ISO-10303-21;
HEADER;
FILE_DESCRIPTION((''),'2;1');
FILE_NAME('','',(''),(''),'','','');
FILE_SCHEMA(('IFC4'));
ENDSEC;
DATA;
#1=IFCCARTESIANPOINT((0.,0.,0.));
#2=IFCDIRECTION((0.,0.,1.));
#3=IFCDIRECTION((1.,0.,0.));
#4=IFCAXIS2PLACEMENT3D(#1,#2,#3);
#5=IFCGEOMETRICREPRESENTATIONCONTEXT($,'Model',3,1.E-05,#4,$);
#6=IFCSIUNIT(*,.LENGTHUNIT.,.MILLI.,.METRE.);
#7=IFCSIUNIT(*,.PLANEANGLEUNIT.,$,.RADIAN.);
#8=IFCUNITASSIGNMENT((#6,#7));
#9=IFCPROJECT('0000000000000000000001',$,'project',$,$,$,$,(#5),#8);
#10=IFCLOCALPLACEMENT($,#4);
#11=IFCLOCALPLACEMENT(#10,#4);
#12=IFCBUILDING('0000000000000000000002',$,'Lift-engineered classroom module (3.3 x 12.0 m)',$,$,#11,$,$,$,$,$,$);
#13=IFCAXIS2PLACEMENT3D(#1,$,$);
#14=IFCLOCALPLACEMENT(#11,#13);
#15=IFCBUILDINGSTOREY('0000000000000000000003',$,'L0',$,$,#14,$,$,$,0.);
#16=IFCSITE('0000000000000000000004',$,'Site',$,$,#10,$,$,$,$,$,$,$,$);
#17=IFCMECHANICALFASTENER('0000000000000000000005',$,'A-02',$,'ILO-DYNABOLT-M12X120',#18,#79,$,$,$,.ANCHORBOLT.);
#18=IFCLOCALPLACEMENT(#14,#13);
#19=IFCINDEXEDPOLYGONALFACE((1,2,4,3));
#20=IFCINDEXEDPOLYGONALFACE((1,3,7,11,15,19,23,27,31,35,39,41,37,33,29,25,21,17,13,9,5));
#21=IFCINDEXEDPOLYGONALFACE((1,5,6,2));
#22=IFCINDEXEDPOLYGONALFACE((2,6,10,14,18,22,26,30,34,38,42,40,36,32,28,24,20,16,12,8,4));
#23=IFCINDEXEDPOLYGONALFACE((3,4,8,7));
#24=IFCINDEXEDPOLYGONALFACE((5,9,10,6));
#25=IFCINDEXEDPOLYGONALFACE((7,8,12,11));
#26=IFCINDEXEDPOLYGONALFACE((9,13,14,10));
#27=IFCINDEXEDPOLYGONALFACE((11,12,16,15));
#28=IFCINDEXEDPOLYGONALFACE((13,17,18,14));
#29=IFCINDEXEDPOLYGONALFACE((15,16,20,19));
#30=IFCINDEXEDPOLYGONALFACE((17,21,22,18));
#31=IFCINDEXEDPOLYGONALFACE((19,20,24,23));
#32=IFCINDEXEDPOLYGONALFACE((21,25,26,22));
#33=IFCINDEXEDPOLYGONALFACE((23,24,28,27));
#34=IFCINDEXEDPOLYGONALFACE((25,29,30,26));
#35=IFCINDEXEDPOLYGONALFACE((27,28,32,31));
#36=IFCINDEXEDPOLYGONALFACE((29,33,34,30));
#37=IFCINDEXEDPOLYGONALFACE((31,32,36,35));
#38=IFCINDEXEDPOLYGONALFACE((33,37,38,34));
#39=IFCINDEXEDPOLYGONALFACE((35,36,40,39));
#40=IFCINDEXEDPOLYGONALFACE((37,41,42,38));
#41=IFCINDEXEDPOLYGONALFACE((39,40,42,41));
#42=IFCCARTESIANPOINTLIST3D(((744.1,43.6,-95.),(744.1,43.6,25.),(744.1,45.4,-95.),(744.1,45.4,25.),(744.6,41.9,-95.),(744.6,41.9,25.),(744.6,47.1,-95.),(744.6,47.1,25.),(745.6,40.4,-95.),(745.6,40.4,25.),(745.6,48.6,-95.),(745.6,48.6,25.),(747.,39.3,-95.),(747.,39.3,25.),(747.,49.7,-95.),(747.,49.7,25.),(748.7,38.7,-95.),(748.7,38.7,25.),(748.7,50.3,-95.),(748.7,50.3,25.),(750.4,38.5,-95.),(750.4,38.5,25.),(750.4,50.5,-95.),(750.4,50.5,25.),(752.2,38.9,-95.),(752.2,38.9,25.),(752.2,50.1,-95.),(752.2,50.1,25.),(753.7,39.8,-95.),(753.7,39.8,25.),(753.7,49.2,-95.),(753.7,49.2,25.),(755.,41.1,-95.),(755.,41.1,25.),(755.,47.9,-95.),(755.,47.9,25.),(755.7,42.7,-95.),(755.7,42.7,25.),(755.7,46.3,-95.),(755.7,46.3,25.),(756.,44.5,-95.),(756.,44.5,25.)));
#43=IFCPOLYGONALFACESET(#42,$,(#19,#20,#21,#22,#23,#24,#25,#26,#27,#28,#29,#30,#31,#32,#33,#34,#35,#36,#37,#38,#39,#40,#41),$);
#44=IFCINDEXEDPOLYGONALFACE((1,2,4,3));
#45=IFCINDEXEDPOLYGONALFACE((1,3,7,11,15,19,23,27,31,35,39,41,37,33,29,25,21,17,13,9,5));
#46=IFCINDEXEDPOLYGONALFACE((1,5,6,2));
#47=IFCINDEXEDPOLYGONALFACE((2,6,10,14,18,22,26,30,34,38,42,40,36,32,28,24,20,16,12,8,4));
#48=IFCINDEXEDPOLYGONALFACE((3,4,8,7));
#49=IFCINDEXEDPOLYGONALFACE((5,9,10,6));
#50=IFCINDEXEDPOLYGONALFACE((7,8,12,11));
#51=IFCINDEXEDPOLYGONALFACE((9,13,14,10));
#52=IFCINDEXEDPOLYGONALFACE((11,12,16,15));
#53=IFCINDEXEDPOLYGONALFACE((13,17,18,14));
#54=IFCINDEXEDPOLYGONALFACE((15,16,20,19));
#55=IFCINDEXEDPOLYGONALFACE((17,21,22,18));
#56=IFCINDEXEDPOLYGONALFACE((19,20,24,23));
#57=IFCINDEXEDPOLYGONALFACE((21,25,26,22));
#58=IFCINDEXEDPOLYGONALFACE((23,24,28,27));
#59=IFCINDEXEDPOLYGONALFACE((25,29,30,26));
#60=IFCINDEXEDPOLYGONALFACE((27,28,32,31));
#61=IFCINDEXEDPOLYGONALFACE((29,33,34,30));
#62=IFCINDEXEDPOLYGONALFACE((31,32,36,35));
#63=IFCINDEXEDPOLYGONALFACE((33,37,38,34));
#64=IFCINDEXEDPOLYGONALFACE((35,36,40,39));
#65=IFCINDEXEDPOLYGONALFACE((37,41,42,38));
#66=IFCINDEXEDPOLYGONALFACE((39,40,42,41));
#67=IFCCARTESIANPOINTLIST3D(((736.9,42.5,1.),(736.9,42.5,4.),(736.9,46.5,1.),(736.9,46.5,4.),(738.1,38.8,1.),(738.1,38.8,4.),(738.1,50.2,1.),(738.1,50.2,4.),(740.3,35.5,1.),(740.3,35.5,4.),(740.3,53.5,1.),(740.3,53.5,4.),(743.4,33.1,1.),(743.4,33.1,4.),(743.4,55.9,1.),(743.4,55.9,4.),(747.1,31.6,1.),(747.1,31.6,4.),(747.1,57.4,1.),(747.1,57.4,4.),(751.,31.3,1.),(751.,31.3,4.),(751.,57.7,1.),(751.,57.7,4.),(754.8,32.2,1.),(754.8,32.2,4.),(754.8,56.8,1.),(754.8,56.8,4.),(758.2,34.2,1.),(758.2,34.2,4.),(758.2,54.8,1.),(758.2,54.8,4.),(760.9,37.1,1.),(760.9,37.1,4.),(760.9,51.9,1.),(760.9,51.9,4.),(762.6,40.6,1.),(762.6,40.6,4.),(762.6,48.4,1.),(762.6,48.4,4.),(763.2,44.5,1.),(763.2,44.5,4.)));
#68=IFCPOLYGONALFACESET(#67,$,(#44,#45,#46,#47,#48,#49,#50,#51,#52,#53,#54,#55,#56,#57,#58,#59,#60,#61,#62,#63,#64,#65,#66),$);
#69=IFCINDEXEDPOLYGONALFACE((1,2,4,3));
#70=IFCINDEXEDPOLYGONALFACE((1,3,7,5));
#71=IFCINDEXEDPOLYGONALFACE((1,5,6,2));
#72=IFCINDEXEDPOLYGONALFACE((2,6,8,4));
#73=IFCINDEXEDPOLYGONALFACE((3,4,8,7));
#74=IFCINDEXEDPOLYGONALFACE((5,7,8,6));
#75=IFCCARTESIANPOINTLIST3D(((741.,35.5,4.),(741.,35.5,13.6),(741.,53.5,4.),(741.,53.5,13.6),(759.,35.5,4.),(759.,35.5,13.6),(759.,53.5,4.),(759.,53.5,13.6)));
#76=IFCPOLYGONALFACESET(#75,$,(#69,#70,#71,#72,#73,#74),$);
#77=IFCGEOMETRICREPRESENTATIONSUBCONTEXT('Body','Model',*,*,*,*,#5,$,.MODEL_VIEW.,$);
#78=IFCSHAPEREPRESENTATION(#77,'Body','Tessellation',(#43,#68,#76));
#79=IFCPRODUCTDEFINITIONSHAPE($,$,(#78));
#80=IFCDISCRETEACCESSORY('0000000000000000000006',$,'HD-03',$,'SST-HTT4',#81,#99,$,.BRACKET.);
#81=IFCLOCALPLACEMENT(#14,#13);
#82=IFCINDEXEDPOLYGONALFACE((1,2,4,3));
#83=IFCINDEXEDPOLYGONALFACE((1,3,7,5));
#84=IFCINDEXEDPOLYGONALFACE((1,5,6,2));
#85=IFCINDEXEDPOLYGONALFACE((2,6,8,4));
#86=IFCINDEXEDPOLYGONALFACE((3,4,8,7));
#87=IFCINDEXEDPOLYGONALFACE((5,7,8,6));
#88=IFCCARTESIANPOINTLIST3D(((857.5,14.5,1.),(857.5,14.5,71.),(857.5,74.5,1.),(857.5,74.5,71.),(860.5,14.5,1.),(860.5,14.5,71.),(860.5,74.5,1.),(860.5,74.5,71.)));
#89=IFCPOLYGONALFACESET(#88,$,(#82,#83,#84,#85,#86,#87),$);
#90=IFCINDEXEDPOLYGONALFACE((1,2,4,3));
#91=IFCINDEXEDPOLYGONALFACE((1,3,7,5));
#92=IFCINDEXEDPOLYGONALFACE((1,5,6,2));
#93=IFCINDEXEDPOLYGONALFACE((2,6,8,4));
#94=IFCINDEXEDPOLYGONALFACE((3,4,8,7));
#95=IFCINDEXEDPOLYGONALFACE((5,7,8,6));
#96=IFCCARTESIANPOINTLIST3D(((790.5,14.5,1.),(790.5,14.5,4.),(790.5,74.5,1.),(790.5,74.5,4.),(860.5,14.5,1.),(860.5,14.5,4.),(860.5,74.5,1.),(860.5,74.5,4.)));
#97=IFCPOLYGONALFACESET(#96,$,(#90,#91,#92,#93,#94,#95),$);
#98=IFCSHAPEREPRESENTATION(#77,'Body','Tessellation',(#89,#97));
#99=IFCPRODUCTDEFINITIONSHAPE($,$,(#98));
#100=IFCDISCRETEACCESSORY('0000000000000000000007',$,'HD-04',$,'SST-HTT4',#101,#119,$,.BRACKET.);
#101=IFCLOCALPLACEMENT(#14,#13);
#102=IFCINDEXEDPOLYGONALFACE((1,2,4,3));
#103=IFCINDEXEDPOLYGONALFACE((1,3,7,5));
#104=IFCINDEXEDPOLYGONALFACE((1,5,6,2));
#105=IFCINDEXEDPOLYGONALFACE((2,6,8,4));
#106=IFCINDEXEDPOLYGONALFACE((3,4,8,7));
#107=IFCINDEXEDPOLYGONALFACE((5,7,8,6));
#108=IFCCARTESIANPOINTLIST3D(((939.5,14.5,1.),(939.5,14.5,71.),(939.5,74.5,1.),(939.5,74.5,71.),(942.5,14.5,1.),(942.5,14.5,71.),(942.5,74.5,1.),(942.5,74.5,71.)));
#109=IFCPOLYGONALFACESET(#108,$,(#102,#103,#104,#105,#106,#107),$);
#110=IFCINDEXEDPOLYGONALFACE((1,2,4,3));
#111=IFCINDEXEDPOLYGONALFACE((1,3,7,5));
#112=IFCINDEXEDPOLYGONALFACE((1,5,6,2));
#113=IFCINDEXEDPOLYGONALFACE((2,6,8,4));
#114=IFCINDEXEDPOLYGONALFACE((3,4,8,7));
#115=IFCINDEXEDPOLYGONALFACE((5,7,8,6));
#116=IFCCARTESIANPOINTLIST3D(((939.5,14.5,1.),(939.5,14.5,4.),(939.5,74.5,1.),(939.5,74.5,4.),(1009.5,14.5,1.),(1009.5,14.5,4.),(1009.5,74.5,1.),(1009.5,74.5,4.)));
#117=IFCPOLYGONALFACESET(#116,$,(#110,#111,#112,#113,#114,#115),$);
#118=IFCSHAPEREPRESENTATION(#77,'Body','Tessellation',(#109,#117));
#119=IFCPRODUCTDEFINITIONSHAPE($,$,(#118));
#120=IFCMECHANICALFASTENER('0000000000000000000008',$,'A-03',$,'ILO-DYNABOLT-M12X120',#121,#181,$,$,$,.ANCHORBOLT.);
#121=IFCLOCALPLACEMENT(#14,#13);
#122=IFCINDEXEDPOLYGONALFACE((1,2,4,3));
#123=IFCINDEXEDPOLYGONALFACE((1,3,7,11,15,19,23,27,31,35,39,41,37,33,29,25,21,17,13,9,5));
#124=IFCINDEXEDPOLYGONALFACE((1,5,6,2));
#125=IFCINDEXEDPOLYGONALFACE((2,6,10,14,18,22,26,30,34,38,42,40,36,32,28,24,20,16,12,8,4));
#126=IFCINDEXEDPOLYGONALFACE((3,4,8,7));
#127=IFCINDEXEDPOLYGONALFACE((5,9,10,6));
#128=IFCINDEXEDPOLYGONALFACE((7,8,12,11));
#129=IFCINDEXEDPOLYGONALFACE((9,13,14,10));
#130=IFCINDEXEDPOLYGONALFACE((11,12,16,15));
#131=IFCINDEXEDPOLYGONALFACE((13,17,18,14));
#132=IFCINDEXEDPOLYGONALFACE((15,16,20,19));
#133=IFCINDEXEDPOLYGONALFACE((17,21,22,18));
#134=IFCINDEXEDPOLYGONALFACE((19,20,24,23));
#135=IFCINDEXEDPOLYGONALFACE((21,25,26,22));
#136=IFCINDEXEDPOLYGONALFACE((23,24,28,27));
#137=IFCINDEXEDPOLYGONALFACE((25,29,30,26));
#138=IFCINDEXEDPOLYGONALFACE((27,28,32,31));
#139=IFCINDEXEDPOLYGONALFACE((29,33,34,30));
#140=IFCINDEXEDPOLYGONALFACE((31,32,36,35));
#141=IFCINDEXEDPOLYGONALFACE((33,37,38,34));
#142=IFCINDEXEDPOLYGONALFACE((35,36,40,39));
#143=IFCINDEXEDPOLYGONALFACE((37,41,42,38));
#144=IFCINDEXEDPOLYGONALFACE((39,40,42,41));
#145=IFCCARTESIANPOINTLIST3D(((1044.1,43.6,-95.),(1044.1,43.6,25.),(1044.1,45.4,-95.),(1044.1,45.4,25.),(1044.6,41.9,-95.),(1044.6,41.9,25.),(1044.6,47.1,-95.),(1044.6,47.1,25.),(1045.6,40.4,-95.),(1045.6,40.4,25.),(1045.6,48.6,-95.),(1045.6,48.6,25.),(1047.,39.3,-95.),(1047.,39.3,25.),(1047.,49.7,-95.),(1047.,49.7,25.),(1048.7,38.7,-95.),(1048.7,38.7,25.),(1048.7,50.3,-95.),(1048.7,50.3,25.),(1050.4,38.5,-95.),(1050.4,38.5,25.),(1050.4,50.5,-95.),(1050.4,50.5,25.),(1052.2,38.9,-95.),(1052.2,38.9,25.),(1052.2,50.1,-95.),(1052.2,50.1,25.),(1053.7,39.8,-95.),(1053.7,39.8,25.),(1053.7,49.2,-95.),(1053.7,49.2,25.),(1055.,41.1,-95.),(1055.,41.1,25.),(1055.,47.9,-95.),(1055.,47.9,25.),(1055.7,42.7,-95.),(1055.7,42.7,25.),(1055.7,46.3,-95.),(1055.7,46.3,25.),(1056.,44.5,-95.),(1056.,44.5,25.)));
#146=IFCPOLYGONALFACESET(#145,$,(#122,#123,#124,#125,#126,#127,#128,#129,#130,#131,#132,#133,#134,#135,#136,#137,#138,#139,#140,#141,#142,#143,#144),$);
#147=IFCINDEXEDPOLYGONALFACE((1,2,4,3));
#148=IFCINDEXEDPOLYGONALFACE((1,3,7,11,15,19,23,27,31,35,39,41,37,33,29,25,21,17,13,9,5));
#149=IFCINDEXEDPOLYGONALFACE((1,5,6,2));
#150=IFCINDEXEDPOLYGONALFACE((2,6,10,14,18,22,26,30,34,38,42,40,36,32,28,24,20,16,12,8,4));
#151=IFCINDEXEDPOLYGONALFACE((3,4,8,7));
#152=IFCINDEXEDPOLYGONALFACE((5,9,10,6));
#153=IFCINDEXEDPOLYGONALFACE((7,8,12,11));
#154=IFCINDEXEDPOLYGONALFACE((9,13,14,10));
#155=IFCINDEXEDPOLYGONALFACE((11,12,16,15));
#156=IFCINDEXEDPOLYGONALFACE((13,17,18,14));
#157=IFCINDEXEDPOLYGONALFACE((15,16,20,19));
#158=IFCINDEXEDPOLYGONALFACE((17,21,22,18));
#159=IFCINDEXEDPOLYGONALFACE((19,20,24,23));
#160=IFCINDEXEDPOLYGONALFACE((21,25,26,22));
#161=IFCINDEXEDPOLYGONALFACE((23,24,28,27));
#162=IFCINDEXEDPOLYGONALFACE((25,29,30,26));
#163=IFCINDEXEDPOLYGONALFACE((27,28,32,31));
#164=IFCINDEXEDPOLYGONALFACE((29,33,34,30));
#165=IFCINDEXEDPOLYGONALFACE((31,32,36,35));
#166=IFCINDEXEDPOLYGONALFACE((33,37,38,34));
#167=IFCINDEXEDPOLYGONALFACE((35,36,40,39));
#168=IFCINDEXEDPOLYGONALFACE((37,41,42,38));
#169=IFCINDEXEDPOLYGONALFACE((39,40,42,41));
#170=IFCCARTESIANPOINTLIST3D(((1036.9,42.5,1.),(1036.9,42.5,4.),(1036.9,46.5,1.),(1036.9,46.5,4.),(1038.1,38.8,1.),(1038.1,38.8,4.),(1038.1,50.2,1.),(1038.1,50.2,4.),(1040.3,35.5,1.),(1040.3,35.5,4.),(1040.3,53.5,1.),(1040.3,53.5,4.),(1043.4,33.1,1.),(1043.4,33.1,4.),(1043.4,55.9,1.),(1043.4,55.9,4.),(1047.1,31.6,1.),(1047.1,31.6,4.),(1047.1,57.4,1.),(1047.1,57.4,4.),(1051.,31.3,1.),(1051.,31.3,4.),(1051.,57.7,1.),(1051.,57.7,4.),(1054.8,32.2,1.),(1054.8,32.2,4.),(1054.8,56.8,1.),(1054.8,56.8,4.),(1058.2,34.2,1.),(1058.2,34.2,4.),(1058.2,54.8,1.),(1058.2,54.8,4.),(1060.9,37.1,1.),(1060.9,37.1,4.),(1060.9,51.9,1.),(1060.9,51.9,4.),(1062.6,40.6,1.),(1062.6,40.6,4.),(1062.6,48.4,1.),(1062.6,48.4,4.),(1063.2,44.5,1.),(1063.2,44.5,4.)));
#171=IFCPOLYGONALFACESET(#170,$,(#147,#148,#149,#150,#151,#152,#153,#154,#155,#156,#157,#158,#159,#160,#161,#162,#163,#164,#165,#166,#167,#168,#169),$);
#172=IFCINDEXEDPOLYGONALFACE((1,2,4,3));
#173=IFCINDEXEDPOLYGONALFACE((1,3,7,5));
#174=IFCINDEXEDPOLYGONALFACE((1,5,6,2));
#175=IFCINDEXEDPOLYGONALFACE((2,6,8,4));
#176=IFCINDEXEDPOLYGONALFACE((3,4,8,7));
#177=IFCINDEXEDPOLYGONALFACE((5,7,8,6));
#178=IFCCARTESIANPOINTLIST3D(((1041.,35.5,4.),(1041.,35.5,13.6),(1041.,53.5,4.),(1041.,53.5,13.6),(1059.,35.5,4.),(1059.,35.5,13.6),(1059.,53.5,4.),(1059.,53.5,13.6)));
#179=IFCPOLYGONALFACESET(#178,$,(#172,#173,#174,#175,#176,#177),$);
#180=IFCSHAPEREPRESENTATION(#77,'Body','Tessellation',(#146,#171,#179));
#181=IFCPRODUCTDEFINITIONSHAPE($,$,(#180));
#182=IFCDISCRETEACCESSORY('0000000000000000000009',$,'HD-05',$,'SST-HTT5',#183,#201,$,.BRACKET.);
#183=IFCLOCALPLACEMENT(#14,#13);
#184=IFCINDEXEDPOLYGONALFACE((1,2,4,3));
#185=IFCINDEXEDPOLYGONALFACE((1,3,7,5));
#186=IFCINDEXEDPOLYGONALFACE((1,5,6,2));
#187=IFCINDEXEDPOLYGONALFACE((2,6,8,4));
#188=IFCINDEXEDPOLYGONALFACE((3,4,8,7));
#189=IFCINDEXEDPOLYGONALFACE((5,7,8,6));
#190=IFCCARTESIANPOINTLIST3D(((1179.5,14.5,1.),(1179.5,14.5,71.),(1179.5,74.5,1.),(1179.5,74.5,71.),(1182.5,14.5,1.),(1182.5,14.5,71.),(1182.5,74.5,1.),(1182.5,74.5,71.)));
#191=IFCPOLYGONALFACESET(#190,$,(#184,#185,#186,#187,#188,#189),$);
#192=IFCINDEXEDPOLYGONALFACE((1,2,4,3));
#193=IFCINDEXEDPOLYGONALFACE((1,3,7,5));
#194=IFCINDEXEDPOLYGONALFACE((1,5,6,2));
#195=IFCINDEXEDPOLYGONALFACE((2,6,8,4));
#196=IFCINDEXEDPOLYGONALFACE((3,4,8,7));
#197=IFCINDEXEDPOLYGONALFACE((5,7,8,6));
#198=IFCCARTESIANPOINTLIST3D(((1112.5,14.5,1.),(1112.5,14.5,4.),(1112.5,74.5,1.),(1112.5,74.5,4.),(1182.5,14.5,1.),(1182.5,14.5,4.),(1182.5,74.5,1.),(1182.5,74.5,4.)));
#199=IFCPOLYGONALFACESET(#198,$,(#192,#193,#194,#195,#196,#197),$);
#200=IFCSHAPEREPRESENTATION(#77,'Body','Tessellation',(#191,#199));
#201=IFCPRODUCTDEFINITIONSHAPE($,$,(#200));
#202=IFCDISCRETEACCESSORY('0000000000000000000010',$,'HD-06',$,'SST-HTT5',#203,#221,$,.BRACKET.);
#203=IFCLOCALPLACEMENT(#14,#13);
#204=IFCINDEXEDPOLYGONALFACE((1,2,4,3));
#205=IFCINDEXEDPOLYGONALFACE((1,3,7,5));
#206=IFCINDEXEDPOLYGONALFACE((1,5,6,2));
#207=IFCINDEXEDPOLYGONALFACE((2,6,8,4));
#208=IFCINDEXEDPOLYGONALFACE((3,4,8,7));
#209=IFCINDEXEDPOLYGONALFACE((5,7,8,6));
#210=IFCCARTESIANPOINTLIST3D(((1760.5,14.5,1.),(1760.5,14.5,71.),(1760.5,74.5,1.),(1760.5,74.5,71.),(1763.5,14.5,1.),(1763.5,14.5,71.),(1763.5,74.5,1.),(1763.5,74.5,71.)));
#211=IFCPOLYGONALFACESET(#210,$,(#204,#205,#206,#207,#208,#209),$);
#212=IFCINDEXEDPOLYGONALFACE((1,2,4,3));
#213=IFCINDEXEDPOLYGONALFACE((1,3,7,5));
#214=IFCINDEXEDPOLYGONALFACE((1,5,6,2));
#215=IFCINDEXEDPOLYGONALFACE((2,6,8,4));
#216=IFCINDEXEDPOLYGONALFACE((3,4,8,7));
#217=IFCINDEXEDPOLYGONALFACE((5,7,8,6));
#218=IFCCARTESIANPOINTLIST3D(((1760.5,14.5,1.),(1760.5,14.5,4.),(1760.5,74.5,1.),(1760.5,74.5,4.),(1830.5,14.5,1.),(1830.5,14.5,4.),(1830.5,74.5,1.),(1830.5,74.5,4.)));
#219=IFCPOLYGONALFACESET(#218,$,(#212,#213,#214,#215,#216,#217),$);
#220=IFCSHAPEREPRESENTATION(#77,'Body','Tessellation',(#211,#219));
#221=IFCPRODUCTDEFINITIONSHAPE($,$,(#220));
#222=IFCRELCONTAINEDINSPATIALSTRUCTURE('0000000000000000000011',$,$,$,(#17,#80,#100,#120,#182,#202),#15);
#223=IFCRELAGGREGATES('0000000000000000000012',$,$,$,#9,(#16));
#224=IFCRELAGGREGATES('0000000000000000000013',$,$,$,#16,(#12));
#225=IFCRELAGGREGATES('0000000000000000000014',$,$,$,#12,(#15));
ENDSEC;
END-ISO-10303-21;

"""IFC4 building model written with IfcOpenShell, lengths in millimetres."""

from ifc_helpers import new_model, si_unit, frame, frame_2d, origin, origin_with_axes, origin_2d, place, context, subcontext, project, spatial, rectangle, circle, extrude, element, save


model = new_model("IFC4")

# Units and contexts
model_context = context("Model", 3, precision=1e-05, world=origin_with_axes())
body_context = subcontext(model_context, "Body", "Model", "MODEL_VIEW")
ifc_project = project(units=[si_unit("LENGTHUNIT", "METRE", prefix="MILLI"), si_unit("PLANEANGLEUNIT", "RADIAN")], contexts=[model_context])

# Site, building, storey
site_placement = place(None, origin_with_axes())
site = spatial("IfcSite", under=ifc_project, at=site_placement, Name="Site")
building_placement = place(site_placement, origin_with_axes())
building = spatial("IfcBuilding", under=site, at=building_placement, Name="Lift-engineered classroom module (3.3 x 12.0 m)")
storey_placement = place(building_placement, origin())
storey = spatial("IfcBuildingStorey", under=building, at=storey_placement, Name="L0", Elevation=0.0)

# Mechanical fastener
mechanical_fastener_1_placement = place(None, frame((750.0, 44.5, 0.0), z_axis=(0.0, 0.0, 1.0), x_axis=(1.0, 0.0, 0.0)))
element("IfcMechanicalFastener", 1, at=mechanical_fastener_1_placement, inside=storey, Name="A-02", ObjectType="ILO-DYNABOLT-M12X120", PredefinedType="ANCHORBOLT", context=body_context, shape_type="SweptSolid", body=[
    extrude(circle(Radius=6.0, at=origin_2d()), frame((0.0, 0.0, -95.0), z_axis=(0.0, 0.0, 1.0), x_axis=(1.0, 0.0, 0.0)), (0.0, 0.0, 1.0), 120.0),
    extrude(circle(Radius=13.2, at=origin_2d()), frame((0.0, 0.0, 1.0), z_axis=(0.0, 0.0, 1.0), x_axis=(1.0, 0.0, 0.0)), (0.0, 0.0, 1.0), 3.0),
    extrude(rectangle(XDim=18.0, YDim=18.0, at=origin_2d()), frame((0.0, 0.0, 4.0), z_axis=(0.0, 0.0, 1.0), x_axis=(1.0, 0.0, 0.0)), (0.0, 0.0, 1.0), 9.6),
])

# Discrete accessories
for number, where, z_axis, x_axis, name in (
    (2, (860.5, 44.5, 0.0), (0.0, 0.0, 1.0), (-1.0, 0.0, 0.0), "HD-03"),
    (3, (939.5, 44.5, 0.0), (0.0, 0.0, 1.0), (1.0, 0.0, 0.0), "HD-04"),
):
    element("IfcDiscreteAccessory", number, at=place(None, frame(where, z_axis=z_axis, x_axis=x_axis)), inside=storey, Name=name, ObjectType="SST-HTT4", PredefinedType="BRACKET", context=body_context, shape_type="SweptSolid", body=[
        extrude(rectangle(XDim=3.0, YDim=60.0, at=frame_2d((1.5, 0.0))), frame((0.0, 0.0, 1.0), z_axis=(0.0, 0.0, 1.0), x_axis=(1.0, 0.0, 0.0)), (0.0, 0.0, 1.0), 70.0),
        extrude(rectangle(XDim=70.0, YDim=60.0, at=frame_2d((35.0, 0.0))), frame((0.0, 0.0, 1.0), z_axis=(0.0, 0.0, 1.0), x_axis=(1.0, 0.0, 0.0)), (0.0, 0.0, 1.0), 3.0),
    ])

# Mechanical fastener
mechanical_fastener_2_placement = place(None, frame((1050.0, 44.5, 0.0), z_axis=(0.0, 0.0, 1.0), x_axis=(1.0, 0.0, 0.0)))
element("IfcMechanicalFastener", 4, at=mechanical_fastener_2_placement, inside=storey, Name="A-03", ObjectType="ILO-DYNABOLT-M12X120", PredefinedType="ANCHORBOLT", context=body_context, shape_type="SweptSolid", body=[
    extrude(circle(Radius=6.0, at=origin_2d()), frame((0.0, 0.0, -95.0), z_axis=(0.0, 0.0, 1.0), x_axis=(1.0, 0.0, 0.0)), (0.0, 0.0, 1.0), 120.0),
    extrude(circle(Radius=13.2, at=origin_2d()), frame((0.0, 0.0, 1.0), z_axis=(0.0, 0.0, 1.0), x_axis=(1.0, 0.0, 0.0)), (0.0, 0.0, 1.0), 3.0),
    extrude(rectangle(XDim=18.0, YDim=18.0, at=origin_2d()), frame((0.0, 0.0, 4.0), z_axis=(0.0, 0.0, 1.0), x_axis=(1.0, 0.0, 0.0)), (0.0, 0.0, 1.0), 9.6),
])

# Discrete accessories
for number, where, z_axis, x_axis, name in (
    (5, (1182.5, 44.5, 0.0), (0.0, 0.0, 1.0), (-1.0, 0.0, 0.0), "HD-05"),
    (6, (1760.5, 44.5, 0.0), (0.0, 0.0, 1.0), (1.0, 0.0, 0.0), "HD-06"),
):
    element("IfcDiscreteAccessory", number, at=place(None, frame(where, z_axis=z_axis, x_axis=x_axis)), inside=storey, Name=name, ObjectType="SST-HTT5", PredefinedType="BRACKET", context=body_context, shape_type="SweptSolid", body=[
        extrude(rectangle(XDim=3.0, YDim=60.0, at=frame_2d((1.5, 0.0))), frame((0.0, 0.0, 1.0), z_axis=(0.0, 0.0, 1.0), x_axis=(1.0, 0.0, 0.0)), (0.0, 0.0, 1.0), 70.0),
        extrude(rectangle(XDim=70.0, YDim=60.0, at=frame_2d((35.0, 0.0))), frame((0.0, 0.0, 1.0), z_axis=(0.0, 0.0, 1.0), x_axis=(1.0, 0.0, 0.0)), (0.0, 0.0, 1.0), 3.0),
    ])

save(model, "model.ifc")
